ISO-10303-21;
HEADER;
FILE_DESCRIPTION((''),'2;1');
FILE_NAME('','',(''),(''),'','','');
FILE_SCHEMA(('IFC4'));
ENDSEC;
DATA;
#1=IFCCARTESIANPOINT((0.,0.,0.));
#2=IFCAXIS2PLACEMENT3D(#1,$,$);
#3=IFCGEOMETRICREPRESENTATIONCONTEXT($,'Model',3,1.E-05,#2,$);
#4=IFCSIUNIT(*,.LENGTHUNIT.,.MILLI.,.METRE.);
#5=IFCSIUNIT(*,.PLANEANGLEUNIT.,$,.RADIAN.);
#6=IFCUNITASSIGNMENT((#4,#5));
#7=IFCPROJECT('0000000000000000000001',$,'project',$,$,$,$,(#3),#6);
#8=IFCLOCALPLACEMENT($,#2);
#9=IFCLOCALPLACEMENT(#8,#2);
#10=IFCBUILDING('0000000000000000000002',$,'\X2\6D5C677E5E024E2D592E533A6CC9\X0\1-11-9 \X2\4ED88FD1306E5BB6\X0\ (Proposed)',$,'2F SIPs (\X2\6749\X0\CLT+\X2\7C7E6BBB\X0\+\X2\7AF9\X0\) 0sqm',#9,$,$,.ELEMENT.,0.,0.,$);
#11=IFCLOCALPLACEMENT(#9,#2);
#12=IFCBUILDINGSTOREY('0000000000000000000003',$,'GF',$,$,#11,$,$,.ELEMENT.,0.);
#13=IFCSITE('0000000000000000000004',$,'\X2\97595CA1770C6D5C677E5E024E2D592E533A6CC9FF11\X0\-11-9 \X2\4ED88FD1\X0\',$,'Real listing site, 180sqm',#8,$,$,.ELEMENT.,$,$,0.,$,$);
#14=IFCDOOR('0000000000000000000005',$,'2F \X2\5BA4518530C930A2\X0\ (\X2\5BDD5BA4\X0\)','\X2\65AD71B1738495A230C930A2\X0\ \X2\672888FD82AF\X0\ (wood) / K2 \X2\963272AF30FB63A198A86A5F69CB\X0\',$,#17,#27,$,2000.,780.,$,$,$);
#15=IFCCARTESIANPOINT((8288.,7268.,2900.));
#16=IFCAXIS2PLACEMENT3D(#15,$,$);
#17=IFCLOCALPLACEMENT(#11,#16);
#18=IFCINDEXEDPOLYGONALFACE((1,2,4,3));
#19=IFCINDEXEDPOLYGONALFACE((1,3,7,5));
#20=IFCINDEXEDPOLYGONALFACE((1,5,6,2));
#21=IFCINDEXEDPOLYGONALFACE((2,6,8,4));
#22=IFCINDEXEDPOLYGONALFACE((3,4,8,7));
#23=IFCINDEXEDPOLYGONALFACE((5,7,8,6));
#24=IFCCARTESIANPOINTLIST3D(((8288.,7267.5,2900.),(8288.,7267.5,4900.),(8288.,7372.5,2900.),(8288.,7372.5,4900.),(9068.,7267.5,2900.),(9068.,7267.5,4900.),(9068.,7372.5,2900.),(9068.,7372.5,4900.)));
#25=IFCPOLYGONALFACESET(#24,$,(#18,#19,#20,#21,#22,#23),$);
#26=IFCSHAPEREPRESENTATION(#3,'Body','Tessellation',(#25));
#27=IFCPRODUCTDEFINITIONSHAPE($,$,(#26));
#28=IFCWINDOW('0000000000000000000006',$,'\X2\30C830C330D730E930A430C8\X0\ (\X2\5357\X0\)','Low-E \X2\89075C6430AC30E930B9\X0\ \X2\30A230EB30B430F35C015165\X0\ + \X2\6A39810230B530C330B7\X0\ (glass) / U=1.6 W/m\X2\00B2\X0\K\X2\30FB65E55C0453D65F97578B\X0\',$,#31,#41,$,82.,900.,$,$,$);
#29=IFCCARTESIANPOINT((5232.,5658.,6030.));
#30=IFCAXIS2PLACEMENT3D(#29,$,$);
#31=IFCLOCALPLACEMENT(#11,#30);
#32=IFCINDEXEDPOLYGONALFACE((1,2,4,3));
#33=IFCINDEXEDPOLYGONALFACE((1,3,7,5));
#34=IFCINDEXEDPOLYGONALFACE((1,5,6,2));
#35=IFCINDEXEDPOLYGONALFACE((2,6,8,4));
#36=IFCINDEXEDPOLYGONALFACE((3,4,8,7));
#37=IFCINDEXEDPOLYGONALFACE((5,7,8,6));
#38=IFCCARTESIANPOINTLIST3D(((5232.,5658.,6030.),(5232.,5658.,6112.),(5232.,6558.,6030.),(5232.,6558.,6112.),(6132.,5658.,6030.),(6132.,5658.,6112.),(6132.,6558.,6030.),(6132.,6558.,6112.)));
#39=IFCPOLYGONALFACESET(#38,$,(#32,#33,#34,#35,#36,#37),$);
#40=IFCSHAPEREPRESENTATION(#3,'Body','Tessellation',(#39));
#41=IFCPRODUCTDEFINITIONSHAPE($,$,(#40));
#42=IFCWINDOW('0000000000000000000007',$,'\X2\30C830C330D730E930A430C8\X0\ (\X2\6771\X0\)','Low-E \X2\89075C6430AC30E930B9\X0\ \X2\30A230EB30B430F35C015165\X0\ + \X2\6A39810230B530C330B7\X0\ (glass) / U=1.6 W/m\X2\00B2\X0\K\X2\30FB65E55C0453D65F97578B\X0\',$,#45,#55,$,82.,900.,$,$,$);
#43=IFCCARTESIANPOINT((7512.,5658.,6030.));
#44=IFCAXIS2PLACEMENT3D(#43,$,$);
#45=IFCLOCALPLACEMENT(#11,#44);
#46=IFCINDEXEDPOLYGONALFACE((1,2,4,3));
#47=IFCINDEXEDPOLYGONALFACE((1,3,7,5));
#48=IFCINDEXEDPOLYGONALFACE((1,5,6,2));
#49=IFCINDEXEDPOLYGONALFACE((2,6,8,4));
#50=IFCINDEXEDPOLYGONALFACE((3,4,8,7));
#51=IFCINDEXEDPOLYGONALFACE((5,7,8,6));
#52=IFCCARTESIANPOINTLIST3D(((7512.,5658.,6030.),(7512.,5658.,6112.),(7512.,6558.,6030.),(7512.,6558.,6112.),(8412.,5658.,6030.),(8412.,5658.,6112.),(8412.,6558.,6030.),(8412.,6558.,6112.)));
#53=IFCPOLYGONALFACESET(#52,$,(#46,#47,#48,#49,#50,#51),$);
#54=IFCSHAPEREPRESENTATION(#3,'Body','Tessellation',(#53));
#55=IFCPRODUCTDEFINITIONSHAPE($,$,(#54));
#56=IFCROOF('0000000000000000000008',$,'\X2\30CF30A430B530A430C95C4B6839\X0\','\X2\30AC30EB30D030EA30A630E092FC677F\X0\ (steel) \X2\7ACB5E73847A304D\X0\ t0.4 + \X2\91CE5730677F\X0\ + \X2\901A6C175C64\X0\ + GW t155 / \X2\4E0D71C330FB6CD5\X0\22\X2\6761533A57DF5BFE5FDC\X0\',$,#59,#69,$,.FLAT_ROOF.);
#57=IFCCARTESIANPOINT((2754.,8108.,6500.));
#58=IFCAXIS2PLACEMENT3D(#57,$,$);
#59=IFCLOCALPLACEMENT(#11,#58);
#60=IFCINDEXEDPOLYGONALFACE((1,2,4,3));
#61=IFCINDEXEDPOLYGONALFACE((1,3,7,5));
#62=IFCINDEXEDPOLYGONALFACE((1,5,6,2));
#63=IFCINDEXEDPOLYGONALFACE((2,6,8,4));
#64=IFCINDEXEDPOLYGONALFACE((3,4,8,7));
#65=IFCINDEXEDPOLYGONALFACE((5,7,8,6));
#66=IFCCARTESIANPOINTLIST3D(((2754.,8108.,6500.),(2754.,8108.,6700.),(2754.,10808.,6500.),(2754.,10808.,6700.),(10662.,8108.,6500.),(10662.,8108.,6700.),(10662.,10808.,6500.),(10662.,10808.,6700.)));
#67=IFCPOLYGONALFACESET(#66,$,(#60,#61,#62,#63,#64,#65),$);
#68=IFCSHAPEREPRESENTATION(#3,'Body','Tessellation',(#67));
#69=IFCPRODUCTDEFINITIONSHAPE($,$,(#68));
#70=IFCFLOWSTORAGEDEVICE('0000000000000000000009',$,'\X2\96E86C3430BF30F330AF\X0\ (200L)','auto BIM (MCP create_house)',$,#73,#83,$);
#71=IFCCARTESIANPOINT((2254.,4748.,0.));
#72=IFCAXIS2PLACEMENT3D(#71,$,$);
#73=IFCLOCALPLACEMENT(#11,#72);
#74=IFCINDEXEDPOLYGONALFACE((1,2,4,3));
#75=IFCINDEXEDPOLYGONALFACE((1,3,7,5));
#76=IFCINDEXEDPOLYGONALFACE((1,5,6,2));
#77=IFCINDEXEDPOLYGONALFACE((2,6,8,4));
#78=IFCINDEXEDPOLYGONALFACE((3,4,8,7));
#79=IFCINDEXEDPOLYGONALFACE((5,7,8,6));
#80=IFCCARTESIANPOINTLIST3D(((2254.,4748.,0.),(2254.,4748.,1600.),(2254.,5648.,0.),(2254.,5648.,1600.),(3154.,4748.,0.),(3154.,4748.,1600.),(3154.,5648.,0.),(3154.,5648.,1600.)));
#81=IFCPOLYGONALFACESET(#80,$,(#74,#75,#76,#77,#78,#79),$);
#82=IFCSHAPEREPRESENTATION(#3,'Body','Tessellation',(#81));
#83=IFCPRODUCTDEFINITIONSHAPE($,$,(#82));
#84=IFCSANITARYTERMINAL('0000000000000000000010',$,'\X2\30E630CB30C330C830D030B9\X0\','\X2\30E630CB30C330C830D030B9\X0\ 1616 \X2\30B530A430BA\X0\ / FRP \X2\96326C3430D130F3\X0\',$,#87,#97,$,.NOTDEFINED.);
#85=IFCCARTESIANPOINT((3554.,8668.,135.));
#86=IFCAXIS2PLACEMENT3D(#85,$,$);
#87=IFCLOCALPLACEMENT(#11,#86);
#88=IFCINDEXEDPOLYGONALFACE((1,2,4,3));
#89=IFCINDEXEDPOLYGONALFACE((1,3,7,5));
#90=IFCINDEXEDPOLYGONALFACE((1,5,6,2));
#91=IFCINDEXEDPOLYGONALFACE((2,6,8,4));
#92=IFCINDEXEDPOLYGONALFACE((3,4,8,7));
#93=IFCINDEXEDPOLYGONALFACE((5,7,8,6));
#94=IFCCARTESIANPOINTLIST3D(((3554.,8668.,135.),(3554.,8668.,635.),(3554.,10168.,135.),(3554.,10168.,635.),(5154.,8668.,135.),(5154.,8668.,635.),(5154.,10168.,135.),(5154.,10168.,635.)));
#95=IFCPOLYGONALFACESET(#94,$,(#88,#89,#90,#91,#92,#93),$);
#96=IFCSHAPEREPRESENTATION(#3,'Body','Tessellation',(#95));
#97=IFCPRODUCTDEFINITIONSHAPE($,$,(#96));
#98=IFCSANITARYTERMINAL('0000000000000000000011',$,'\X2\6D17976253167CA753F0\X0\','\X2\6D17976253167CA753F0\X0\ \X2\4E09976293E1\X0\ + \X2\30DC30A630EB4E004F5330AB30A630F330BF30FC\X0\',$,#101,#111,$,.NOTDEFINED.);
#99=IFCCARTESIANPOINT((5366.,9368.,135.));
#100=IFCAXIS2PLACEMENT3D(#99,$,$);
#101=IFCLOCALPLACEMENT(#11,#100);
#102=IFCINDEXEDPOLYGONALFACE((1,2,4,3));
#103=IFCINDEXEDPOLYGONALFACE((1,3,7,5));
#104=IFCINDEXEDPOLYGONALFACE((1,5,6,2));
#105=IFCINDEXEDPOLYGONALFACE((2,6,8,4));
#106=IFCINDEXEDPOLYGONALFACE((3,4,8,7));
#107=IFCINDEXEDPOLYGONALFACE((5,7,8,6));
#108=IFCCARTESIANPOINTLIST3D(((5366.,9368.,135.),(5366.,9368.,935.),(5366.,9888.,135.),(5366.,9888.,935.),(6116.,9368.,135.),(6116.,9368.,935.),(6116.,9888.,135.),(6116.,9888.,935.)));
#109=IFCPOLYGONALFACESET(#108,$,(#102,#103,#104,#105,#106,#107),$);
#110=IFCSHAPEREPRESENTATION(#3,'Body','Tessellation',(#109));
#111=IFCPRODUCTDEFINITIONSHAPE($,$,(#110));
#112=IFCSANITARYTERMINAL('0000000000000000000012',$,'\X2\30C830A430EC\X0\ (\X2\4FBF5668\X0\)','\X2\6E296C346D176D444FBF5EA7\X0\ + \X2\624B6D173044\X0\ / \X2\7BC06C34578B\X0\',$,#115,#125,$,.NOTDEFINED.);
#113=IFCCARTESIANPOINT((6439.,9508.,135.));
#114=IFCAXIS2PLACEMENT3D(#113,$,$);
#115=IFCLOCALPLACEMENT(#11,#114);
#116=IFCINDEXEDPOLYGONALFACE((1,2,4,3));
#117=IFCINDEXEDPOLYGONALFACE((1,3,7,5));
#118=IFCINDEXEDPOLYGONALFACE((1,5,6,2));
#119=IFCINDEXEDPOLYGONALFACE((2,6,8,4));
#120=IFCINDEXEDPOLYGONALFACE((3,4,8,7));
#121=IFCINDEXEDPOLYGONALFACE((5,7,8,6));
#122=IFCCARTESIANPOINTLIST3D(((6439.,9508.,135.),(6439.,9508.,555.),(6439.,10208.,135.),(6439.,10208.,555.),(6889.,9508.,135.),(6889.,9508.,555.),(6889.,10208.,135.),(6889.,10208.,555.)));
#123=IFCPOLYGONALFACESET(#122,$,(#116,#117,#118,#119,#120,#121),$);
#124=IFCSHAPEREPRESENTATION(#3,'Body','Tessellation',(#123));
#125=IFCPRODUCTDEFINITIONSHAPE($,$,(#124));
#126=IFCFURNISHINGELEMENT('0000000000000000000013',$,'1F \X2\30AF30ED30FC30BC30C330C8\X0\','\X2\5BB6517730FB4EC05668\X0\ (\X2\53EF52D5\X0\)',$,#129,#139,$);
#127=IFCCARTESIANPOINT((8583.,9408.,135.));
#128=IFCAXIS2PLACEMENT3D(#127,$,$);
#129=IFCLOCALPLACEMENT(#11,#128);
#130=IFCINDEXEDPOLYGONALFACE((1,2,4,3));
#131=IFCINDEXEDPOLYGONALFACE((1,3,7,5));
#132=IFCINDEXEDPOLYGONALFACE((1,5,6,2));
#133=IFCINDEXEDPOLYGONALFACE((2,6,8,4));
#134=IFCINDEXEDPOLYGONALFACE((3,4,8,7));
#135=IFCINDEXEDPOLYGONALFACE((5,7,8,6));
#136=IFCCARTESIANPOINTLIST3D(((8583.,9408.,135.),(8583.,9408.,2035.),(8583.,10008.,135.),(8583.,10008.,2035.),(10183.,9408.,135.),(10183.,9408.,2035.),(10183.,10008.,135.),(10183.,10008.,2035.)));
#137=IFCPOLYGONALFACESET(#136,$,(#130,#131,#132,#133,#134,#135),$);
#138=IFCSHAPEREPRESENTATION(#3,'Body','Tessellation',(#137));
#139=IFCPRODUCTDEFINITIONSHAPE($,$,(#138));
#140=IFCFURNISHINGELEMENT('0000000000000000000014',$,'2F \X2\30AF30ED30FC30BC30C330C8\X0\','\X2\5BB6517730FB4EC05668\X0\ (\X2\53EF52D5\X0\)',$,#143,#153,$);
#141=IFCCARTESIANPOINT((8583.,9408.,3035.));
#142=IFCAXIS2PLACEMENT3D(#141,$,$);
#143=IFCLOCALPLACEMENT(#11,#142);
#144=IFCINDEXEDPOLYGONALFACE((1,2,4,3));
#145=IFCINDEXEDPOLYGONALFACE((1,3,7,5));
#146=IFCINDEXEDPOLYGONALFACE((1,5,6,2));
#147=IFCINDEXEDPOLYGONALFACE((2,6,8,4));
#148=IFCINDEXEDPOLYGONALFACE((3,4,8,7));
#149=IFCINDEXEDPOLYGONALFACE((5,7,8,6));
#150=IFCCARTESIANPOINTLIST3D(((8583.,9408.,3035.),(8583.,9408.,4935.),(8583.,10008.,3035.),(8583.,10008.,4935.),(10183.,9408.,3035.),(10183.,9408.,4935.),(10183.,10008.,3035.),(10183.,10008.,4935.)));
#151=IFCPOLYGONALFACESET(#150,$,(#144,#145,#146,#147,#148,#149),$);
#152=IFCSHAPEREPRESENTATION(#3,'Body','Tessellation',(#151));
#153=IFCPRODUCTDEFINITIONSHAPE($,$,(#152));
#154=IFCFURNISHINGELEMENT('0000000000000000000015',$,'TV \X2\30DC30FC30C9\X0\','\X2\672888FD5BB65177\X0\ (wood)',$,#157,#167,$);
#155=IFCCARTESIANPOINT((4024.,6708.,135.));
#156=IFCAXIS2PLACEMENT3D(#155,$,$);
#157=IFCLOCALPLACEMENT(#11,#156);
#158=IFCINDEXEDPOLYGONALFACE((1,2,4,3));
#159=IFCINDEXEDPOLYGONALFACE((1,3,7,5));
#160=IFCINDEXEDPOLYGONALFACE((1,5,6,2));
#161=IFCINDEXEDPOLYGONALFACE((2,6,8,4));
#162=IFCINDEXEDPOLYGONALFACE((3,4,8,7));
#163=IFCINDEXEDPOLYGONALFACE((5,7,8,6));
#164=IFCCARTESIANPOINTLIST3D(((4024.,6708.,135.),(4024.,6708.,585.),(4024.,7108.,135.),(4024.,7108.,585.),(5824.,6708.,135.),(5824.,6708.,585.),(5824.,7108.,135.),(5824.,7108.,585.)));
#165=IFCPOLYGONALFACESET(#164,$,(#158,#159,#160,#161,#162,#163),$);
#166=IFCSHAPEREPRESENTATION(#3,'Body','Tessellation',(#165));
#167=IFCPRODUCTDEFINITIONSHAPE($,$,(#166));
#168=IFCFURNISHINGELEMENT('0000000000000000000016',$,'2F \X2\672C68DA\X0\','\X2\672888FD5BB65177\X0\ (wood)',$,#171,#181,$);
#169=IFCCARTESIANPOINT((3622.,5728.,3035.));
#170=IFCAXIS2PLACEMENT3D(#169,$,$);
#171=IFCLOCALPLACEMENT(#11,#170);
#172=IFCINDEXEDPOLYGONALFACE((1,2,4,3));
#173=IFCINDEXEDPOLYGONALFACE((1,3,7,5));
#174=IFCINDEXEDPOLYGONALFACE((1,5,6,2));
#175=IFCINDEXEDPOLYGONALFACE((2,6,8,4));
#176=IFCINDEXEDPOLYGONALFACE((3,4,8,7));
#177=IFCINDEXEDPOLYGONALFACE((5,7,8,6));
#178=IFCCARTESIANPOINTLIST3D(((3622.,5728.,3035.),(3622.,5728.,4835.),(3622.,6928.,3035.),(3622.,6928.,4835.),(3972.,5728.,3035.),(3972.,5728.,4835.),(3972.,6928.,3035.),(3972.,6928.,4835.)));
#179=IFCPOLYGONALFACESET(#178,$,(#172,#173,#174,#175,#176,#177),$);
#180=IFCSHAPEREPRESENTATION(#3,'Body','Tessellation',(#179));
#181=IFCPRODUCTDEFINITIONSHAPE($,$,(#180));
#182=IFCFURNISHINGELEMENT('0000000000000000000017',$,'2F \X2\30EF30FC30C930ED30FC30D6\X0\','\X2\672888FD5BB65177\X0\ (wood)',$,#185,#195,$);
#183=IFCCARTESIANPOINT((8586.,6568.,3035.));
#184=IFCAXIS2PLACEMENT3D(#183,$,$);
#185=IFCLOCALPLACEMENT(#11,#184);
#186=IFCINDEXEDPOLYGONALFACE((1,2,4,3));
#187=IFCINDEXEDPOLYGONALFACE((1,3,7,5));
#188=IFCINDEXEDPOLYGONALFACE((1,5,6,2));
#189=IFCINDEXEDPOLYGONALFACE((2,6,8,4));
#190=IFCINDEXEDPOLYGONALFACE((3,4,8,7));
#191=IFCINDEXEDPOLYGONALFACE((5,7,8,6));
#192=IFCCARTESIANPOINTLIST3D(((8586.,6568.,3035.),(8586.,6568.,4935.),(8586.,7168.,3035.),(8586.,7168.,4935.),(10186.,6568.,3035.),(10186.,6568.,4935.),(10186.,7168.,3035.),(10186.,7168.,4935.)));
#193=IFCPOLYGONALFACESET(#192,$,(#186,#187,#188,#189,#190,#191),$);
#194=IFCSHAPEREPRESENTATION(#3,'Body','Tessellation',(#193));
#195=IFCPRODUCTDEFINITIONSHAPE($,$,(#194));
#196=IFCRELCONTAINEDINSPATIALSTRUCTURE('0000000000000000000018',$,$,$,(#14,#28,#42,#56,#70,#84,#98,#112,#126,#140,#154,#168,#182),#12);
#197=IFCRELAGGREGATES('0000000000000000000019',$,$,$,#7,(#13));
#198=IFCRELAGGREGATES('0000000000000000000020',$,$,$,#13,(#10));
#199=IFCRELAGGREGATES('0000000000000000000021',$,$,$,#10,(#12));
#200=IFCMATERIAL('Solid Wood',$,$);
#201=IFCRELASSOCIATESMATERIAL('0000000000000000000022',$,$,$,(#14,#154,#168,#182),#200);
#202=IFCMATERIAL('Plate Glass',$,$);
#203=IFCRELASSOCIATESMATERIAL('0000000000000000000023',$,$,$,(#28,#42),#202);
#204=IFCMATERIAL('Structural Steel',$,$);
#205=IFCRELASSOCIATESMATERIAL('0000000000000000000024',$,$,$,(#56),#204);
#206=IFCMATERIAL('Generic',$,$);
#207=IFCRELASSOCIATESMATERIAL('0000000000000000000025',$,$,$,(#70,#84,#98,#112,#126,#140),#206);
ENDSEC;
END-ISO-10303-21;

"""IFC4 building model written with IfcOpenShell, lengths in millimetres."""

from ifc_helpers import new_model, si_unit, frame, frame_2d, origin, place, context, project, spatial, rectangle, extrude, material, element, save


model = new_model("IFC4")

# Units and contexts
model_context = context("Model", 3, precision=1e-05, world=origin())
ifc_project = project(units=[si_unit("LENGTHUNIT", "METRE", prefix="MILLI"), si_unit("PLANEANGLEUNIT", "RADIAN")], contexts=[model_context])

# Site, building, storey
site_placement = place(None, origin())
site = spatial("IfcSite", under=ifc_project, at=site_placement, Name="静岡県浜松市中央区泉１-11-9 付近", ObjectType="Real listing site, 180sqm", CompositionType="ELEMENT", RefElevation=0.0)
building_placement = place(site_placement, origin())
building = spatial("IfcBuilding", under=site, at=building_placement, Name="浜松市中央区泉1-11-9 付近の家 (Proposed)", ObjectType="2F SIPs (杉CLT+籾殻+竹) 0sqm", CompositionType="ELEMENT", ElevationOfRefHeight=0.0, ElevationOfTerrain=0.0)
storey_placement = place(building_placement, origin())
storey = spatial("IfcBuildingStorey", under=building, at=storey_placement, Name="GF", CompositionType="ELEMENT", Elevation=0.0)

# Shared definitions
ifc_material_1 = material(Name="Solid Wood")
ifc_material_2 = material(Name="Plate Glass")

# Door
door_1_placement = place(storey_placement, frame((8288.0, 7268.0, 2900.0)))
element("IfcDoor", 1, at=door_1_placement, inside=storey, material=ifc_material_1, Name="2F 室内ドア (寝室)", Description="断熱玄関ドア 木製芯 (wood) / K2 防犯・採風機構", OverallHeight=2000.0, OverallWidth=780.0, context=model_context, shape_type="SweptSolid", body=[
    extrude(rectangle(XDim=780.0, YDim=105.0, at=frame_2d((390.0, 52.0))), frame((8288.0, 7268.0, 2900.0)), (0.0, 0.0, 1.0), 2000.0),
])

# Windows
window_1_placement = place(storey_placement, frame((5232.0, 5658.0, 6030.0)))
element("IfcWindow", 2, at=window_1_placement, inside=storey, material=ifc_material_2, Name="トップライト (南)", Description="Low-E 複層ガラス アルゴン封入 + 樹脂サッシ (glass) / U=1.6 W/m²K・日射取得型", OverallHeight=82.0, OverallWidth=900.0, context=model_context, shape_type="SweptSolid", body=[
    extrude(rectangle(XDim=900.0, YDim=900.0, at=frame_2d((450.0, 450.0))), frame((5232.0, 5658.0, 6030.0)), (0.0, 0.0, 1.0), 82.0),
])
window_2_placement = place(storey_placement, frame((7512.0, 5658.0, 6030.0)))
element("IfcWindow", 3, at=window_2_placement, inside=storey, material=ifc_material_2, Name="トップライト (東)", Description="Low-E 複層ガラス アルゴン封入 + 樹脂サッシ (glass) / U=1.6 W/m²K・日射取得型", OverallHeight=82.0, OverallWidth=900.0, context=model_context, shape_type="SweptSolid", body=[
    extrude(rectangle(XDim=900.0, YDim=900.0, at=frame_2d((450.0, 450.0))), frame((7512.0, 5658.0, 6030.0)), (0.0, 0.0, 1.0), 82.0),
])

# Roof
ifc_material_3 = material(Name="Structural Steel")
roof_placement = place(storey_placement, frame((2754.0, 8108.0, 6500.0)))
element("IfcRoof", 4, at=roof_placement, inside=storey, material=ifc_material_3, Name="ハイサイド屋根", Description="ガルバリウム鋼板 (steel) 立平葺き t0.4 + 野地板 + 通気層 + GW t155 / 不燃・法22条区域対応", PredefinedType="FLAT_ROOF", context=model_context, shape_type="SweptSolid", body=[
    extrude(rectangle(XDim=7908.0, YDim=2700.0, at=frame_2d((3954.0, 1350.0))), frame((2754.0, 8108.0, 6500.0)), (0.0, 0.0, 1.0), 200.0),
])

# Flow storage device
ifc_material_4 = material(Name="Generic")
flow_storage_device_placement = place(storey_placement, frame((2254.0, 4748.0, 0.0)))
element("IfcFlowStorageDevice", 5, at=flow_storage_device_placement, inside=storey, material=ifc_material_4, Name="雨水タンク (200L)", Description="auto BIM (MCP create_house)", context=model_context, shape_type="SweptSolid", body=[
    extrude(rectangle(XDim=900.0, YDim=900.0, at=frame_2d((450.0, 450.0))), frame((2254.0, 4748.0, 0.0)), (0.0, 0.0, 1.0), 1600.0),
])

# Sanitary terminals
sanitary_terminal_1_placement = place(storey_placement, frame((3554.0, 8668.0, 135.0)))
element("IfcSanitaryTerminal", 6, at=sanitary_terminal_1_placement, inside=storey, material=ifc_material_4, Name="ユニットバス", Description="ユニットバス 1616 サイズ / FRP 防水パン", PredefinedType="NOTDEFINED", context=model_context, shape_type="SweptSolid", body=[
    extrude(rectangle(XDim=1600.0, YDim=1500.0, at=frame_2d((800.0, 750.0))), frame((3554.0, 8668.0, 135.0)), (0.0, 0.0, 1.0), 500.0),
])
sanitary_terminal_2_placement = place(storey_placement, frame((5366.0, 9368.0, 135.0)))
element("IfcSanitaryTerminal", 7, at=sanitary_terminal_2_placement, inside=storey, material=ifc_material_4, Name="洗面化粧台", Description="洗面化粧台 三面鏡 + ボウル一体カウンター", PredefinedType="NOTDEFINED", context=model_context, shape_type="SweptSolid", body=[
    extrude(rectangle(XDim=750.0, YDim=520.0, at=frame_2d((375.0, 260.0))), frame((5366.0, 9368.0, 135.0)), (0.0, 0.0, 1.0), 800.0),
])
sanitary_terminal_3_placement = place(storey_placement, frame((6439.0, 9508.0, 135.0)))
element("IfcSanitaryTerminal", 8, at=sanitary_terminal_3_placement, inside=storey, material=ifc_material_4, Name="トイレ (便器)", Description="温水洗浄便座 + 手洗い / 節水型", PredefinedType="NOTDEFINED", context=model_context, shape_type="SweptSolid", body=[
    extrude(rectangle(XDim=450.0, YDim=700.0, at=frame_2d((225.0, 350.0))), frame((6439.0, 9508.0, 135.0)), (0.0, 0.0, 1.0), 420.0),
])

# Furnishing elements
furnishing_1_placement = place(storey_placement, frame((8583.0, 9408.0, 135.0)))
element("IfcFurnishingElement", 9, at=furnishing_1_placement, inside=storey, material=ifc_material_4, Name="1F クローゼット", Description="家具・什器 (可動)", context=model_context, shape_type="SweptSolid", body=[
    extrude(rectangle(XDim=1600.0, YDim=600.0, at=frame_2d((800.0, 300.0))), frame((8583.0, 9408.0, 135.0)), (0.0, 0.0, 1.0), 1900.0),
])
furnishing_2_placement = place(storey_placement, frame((8583.0, 9408.0, 3035.0)))
element("IfcFurnishingElement", 10, at=furnishing_2_placement, inside=storey, material=ifc_material_4, Name="2F クローゼット", Description="家具・什器 (可動)", context=model_context, shape_type="SweptSolid", body=[
    extrude(rectangle(XDim=1600.0, YDim=600.0, at=frame_2d((800.0, 300.0))), frame((8583.0, 9408.0, 3035.0)), (0.0, 0.0, 1.0), 1900.0),
])
furnishing_3_placement = place(storey_placement, frame((4024.0, 6708.0, 135.0)))
element("IfcFurnishingElement", 11, at=furnishing_3_placement, inside=storey, material=ifc_material_1, Name="TV ボード", Description="木製家具 (wood)", context=model_context, shape_type="SweptSolid", body=[
    extrude(rectangle(XDim=1800.0, YDim=400.0, at=frame_2d((900.0, 200.0))), frame((4024.0, 6708.0, 135.0)), (0.0, 0.0, 1.0), 450.0),
])
furnishing_4_placement = place(storey_placement, frame((3622.0, 5728.0, 3035.0)))
element("IfcFurnishingElement", 12, at=furnishing_4_placement, inside=storey, material=ifc_material_1, Name="2F 本棚", Description="木製家具 (wood)", context=model_context, shape_type="SweptSolid", body=[
    extrude(rectangle(XDim=350.0, YDim=1200.0, at=frame_2d((175.0, 600.0))), frame((3622.0, 5728.0, 3035.0)), (0.0, 0.0, 1.0), 1800.0),
])
furnishing_5_placement = place(storey_placement, frame((8586.0, 6568.0, 3035.0)))
element("IfcFurnishingElement", 13, at=furnishing_5_placement, inside=storey, material=ifc_material_1, Name="2F ワードローブ", Description="木製家具 (wood)", context=model_context, shape_type="SweptSolid", body=[
    extrude(rectangle(XDim=1600.0, YDim=600.0, at=frame_2d((800.0, 300.0))), frame((8586.0, 6568.0, 3035.0)), (0.0, 0.0, 1.0), 1900.0),
])

save(model, "model.ifc")
